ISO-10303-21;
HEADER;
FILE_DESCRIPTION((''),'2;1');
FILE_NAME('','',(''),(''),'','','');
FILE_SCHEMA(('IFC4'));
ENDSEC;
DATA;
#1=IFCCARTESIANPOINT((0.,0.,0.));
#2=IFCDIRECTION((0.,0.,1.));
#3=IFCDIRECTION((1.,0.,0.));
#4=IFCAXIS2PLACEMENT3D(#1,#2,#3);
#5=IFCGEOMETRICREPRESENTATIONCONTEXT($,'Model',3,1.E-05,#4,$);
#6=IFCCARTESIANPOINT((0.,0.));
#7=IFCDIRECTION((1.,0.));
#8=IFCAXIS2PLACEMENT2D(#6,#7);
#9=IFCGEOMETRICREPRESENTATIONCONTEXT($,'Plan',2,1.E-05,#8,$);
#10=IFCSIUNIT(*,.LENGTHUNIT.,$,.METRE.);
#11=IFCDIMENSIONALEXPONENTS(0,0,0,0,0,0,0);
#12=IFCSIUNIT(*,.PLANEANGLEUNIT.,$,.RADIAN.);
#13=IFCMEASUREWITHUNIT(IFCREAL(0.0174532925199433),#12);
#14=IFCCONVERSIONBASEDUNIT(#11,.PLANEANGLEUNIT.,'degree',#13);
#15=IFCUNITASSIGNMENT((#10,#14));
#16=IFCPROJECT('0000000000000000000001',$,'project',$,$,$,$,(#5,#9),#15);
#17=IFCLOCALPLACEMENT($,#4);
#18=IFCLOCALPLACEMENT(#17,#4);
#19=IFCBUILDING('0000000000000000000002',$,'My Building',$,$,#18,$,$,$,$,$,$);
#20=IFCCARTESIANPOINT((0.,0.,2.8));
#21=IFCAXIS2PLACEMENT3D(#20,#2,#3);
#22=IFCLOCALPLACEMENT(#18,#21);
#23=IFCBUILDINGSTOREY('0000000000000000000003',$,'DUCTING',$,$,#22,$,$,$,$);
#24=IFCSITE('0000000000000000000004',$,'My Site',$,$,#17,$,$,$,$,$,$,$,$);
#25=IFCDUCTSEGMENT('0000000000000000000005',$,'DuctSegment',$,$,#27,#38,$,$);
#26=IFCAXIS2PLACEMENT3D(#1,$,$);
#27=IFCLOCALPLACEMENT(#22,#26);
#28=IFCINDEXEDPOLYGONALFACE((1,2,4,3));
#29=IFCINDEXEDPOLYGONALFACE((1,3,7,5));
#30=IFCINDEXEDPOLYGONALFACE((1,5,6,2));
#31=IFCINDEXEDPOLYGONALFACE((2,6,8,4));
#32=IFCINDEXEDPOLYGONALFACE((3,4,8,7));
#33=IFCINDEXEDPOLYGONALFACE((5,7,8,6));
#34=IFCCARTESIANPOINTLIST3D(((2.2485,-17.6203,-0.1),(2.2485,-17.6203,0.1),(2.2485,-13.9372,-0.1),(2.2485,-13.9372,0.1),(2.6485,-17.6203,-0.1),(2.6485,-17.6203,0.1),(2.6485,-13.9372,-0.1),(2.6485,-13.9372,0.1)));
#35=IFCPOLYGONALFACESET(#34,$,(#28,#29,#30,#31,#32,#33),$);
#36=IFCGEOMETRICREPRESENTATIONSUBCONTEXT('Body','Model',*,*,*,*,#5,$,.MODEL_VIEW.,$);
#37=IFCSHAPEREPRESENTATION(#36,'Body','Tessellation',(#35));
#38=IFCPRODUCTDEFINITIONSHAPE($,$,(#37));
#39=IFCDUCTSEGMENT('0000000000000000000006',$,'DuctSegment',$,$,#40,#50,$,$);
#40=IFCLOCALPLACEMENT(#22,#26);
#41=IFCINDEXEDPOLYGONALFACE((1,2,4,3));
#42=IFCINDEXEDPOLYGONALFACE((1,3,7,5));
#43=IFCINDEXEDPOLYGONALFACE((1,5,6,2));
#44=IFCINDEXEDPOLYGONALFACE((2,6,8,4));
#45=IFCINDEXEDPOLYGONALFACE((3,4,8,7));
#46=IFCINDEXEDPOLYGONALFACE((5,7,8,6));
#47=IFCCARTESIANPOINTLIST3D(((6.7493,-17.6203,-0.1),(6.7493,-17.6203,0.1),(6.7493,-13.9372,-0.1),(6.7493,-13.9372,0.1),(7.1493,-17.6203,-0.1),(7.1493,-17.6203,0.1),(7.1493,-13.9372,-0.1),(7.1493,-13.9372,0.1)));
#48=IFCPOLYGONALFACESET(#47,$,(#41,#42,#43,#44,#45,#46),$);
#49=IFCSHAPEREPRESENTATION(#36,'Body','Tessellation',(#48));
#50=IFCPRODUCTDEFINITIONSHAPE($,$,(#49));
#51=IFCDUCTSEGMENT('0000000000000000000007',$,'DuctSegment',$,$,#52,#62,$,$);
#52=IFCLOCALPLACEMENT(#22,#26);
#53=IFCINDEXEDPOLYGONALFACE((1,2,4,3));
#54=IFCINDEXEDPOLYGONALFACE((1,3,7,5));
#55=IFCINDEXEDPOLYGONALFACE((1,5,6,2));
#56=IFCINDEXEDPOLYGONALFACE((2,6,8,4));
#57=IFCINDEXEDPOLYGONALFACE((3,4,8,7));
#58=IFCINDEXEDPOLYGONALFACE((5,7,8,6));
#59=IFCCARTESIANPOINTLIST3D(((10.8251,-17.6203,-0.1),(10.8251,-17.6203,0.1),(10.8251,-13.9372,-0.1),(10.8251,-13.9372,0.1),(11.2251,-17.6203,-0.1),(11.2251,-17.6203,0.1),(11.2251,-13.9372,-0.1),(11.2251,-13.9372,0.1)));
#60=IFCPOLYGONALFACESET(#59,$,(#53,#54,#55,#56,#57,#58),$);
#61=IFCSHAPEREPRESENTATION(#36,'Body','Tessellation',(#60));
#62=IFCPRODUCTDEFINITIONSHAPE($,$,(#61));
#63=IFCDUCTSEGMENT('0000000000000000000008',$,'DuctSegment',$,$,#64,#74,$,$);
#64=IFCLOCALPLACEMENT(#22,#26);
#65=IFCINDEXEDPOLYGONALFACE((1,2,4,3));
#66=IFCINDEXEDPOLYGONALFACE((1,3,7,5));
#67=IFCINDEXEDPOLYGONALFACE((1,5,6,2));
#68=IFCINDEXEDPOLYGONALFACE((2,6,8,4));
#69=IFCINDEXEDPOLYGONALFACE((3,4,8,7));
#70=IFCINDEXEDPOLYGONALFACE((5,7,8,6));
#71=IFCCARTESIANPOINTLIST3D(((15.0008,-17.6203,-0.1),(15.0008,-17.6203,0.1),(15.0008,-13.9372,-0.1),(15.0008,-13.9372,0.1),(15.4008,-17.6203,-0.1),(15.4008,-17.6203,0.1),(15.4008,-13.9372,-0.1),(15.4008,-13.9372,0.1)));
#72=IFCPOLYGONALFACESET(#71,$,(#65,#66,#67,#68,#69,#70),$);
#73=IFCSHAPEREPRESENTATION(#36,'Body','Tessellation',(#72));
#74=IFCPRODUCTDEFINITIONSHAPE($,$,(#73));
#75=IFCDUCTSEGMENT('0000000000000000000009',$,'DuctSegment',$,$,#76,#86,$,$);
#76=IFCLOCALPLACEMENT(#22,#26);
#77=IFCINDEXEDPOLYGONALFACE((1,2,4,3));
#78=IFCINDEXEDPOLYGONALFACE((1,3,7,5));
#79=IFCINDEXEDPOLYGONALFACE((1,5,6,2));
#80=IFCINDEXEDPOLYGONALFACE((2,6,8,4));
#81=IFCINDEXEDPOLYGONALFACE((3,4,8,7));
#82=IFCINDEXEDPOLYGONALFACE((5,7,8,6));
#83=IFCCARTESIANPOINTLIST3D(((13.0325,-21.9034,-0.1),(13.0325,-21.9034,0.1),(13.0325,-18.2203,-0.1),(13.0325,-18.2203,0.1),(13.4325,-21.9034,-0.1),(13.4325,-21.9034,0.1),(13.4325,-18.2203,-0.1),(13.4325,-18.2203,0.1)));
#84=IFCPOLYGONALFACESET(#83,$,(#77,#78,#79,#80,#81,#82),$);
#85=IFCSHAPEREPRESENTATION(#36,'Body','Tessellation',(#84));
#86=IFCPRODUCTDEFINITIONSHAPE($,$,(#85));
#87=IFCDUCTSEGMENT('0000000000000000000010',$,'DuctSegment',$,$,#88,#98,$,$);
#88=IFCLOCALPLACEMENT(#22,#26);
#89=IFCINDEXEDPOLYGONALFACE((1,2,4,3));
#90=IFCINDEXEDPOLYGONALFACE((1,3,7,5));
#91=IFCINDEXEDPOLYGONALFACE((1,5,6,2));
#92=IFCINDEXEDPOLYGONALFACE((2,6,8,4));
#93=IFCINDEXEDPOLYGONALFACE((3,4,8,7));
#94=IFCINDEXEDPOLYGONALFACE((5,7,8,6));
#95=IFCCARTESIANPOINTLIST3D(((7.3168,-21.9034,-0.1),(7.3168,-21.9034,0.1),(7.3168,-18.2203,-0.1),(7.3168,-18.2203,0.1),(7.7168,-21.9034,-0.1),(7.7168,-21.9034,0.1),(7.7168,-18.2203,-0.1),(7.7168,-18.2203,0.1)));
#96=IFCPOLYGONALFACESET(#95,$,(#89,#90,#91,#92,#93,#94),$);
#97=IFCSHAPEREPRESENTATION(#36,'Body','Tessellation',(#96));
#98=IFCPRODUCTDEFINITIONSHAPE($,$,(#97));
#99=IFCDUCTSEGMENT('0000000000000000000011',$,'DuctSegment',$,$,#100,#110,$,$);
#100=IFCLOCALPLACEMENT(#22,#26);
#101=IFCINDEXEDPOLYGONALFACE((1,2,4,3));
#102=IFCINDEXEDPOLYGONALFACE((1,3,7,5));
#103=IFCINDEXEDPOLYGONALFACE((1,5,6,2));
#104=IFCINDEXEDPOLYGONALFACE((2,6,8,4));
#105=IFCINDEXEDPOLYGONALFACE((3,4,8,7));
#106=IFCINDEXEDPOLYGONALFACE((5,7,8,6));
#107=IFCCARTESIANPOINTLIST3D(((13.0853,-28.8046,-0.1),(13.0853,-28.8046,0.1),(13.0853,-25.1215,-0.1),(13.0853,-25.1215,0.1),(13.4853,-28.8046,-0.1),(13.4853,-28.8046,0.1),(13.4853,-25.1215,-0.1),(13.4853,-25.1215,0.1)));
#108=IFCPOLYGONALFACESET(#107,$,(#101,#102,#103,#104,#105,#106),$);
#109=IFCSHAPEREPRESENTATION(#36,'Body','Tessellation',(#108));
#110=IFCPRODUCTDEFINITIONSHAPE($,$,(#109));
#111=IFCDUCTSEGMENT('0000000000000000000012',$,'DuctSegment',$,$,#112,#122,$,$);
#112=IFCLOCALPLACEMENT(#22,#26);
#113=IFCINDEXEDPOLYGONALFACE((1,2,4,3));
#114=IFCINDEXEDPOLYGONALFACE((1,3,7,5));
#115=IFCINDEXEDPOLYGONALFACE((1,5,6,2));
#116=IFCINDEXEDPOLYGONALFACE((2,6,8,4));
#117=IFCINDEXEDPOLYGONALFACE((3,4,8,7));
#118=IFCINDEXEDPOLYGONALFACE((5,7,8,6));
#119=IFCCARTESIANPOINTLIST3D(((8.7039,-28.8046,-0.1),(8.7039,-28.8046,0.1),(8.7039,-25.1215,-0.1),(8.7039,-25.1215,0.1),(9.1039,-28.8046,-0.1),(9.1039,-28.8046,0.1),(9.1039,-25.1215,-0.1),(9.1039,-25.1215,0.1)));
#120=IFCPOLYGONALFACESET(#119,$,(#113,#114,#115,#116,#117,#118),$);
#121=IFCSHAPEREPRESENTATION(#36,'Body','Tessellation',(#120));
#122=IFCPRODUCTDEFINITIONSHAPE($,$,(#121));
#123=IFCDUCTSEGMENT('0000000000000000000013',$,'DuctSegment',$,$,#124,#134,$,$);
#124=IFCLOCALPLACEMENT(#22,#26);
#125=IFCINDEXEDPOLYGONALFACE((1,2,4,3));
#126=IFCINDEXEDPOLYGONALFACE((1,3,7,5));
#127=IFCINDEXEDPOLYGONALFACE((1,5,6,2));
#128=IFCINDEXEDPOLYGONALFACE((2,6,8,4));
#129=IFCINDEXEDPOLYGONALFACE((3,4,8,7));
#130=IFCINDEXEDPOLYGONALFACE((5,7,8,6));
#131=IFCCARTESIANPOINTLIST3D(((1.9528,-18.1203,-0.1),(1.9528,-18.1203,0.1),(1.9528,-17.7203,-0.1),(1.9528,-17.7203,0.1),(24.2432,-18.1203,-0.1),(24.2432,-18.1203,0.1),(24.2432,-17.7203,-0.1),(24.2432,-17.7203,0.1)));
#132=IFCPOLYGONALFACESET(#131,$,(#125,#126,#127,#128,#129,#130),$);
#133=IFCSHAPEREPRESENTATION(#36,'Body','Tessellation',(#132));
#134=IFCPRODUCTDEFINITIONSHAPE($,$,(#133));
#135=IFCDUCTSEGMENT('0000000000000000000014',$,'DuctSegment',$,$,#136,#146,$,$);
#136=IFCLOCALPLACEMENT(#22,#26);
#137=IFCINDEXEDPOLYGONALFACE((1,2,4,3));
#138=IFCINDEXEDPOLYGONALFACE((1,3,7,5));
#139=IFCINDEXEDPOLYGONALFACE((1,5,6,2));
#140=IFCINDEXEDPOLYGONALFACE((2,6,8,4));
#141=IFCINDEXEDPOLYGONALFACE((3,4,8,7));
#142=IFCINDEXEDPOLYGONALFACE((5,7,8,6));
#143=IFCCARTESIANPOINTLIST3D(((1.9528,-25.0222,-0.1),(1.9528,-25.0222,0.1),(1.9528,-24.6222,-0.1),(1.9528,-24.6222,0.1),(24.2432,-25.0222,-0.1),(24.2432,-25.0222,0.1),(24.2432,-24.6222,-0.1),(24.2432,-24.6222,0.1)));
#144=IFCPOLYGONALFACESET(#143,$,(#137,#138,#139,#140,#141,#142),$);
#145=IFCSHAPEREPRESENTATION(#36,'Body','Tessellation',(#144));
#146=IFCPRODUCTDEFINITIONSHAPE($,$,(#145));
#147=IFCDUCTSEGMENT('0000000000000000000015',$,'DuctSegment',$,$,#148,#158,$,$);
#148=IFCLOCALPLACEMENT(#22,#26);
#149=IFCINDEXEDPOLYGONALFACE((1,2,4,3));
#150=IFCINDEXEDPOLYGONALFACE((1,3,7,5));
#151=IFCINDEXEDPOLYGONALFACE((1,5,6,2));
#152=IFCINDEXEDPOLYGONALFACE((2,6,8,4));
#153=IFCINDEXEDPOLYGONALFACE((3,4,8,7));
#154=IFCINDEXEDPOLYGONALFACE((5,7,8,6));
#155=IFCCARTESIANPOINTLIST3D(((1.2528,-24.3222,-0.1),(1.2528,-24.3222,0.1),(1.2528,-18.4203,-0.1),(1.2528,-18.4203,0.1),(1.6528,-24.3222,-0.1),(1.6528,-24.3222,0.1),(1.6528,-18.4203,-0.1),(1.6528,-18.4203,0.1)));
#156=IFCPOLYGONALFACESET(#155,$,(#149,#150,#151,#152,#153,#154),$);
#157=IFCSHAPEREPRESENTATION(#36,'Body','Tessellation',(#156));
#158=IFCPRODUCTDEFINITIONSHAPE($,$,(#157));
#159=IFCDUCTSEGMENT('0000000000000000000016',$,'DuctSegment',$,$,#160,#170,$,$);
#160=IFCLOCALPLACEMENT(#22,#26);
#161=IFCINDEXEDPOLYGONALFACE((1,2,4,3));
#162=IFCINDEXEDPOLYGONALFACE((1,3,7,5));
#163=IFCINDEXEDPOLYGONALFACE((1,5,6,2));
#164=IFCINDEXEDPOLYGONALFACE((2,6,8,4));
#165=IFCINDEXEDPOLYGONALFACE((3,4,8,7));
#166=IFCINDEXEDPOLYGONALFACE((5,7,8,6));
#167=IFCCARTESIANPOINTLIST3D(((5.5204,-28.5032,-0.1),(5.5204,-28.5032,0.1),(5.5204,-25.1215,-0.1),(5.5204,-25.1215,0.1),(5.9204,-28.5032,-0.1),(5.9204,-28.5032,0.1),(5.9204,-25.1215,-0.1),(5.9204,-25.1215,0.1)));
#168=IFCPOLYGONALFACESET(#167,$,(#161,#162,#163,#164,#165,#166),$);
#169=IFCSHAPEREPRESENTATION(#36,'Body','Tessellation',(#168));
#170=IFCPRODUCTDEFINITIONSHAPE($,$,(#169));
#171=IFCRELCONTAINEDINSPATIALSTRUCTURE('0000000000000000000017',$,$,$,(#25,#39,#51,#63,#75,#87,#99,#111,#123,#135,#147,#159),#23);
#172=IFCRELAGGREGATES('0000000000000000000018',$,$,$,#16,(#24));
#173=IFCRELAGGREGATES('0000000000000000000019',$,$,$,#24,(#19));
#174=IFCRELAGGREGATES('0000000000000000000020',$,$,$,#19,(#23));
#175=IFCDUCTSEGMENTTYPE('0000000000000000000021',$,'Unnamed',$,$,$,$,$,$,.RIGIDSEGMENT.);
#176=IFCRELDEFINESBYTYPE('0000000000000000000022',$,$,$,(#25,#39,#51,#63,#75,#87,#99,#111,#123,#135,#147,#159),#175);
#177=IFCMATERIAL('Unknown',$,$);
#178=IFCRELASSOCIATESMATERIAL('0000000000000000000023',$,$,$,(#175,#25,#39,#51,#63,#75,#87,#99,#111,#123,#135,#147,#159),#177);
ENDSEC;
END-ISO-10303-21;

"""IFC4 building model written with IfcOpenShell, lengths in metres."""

from ifc_helpers import new_model, entity, si_unit, converted_unit, frame, origin_with_axes, origin_2d_with_axis, place, context, subcontext, project, spatial, rectangle, extrude, material, material_profile, profile_set, profile_usage, type_object, element, save


model = new_model("IFC4")

# Units and contexts
model_context = context("Model", 3, precision=1e-05, world=origin_with_axes())
plan_context = context("Plan", 2, precision=1e-05, world=origin_2d_with_axis())
body_context = subcontext(model_context, "Body", "Model", "MODEL_VIEW")
ifc_project = project(units=[si_unit("LENGTHUNIT", "METRE"), converted_unit("PLANEANGLEUNIT", "degree", entity("IfcReal", 0.0174532925199433), si_unit("PLANEANGLEUNIT", "RADIAN"), dimensions=[0, 0, 0, 0, 0, 0, 0])], contexts=[model_context, plan_context])

# Site, building, storey
site_placement = place(None, origin_with_axes())
site = spatial("IfcSite", under=ifc_project, at=site_placement, Name="My Site")
building_placement = place(site_placement, origin_with_axes())
building = spatial("IfcBuilding", under=site, at=building_placement, Name="My Building")
storey_placement = place(building_placement, frame((0.0, 0.0, 2.8), z_axis=(0.0, 0.0, 1.0), x_axis=(1.0, 0.0, 0.0)))
storey = spatial("IfcBuildingStorey", under=building, at=storey_placement, Name="DUCTING")

# Duct segments
ifc_material = material(Name="Unknown")
ifc_material_profile_1 = material_profile(ifc_material, rectangle(XDim=0.4, YDim=0.2))
ifc_profile_set_1 = profile_set([ifc_material_profile_1])
ifc_profile_usage_1 = profile_usage(ifc_profile_set_1, cardinal=5)
duct_segment_type = type_object("IfcDuctSegmentType", Name="Unnamed", PredefinedType="RIGIDSEGMENT", material=ifc_profile_set_1)
duct_segment_1_placement = place(storey_placement, frame((2.4485, -13.9372, 0.0), z_axis=(0.0, -1.0, 0.0), x_axis=(1.0, 0.0, 0.0)))
element("IfcDuctSegment", 1, at=duct_segment_1_placement, inside=storey, type_object=duct_segment_type, material=ifc_profile_usage_1, Name="DuctSegment", context=body_context, shape_type="SweptSolid", body=[
    extrude(rectangle(XDim=0.4, YDim=0.2), origin_with_axes(), (0.0, 0.0, 1.0), 3.6831),
])
ifc_profile_usage_2 = profile_usage(ifc_profile_set_1, cardinal=5)
duct_segment_2_placement = place(storey_placement, frame((6.9493, -13.9372, 0.0), z_axis=(0.0, -1.0, 0.0), x_axis=(1.0, 0.0, 0.0)))
element("IfcDuctSegment", 2, at=duct_segment_2_placement, inside=storey, type_object=duct_segment_type, material=ifc_profile_usage_2, Name="DuctSegment", context=body_context, shape_type="SweptSolid", body=[
    extrude(rectangle(XDim=0.4, YDim=0.2), origin_with_axes(), (0.0, 0.0, 1.0), 3.6831),
])
ifc_profile_usage_3 = profile_usage(ifc_profile_set_1, cardinal=5)
duct_segment_3_placement = place(storey_placement, frame((11.0251, -13.9372, 0.0), z_axis=(0.0, -1.0, 0.0), x_axis=(1.0, 0.0, 0.0)))
element("IfcDuctSegment", 3, at=duct_segment_3_placement, inside=storey, type_object=duct_segment_type, material=ifc_profile_usage_3, Name="DuctSegment", context=body_context, shape_type="SweptSolid", body=[
    extrude(rectangle(XDim=0.4, YDim=0.2), origin_with_axes(), (0.0, 0.0, 1.0), 3.6831),
])
ifc_profile_usage_4 = profile_usage(ifc_profile_set_1, cardinal=5)
duct_segment_4_placement = place(storey_placement, frame((15.2008, -13.9372, 0.0), z_axis=(0.0, -1.0, 0.0), x_axis=(1.0, 0.0, 0.0)))
element("IfcDuctSegment", 4, at=duct_segment_4_placement, inside=storey, type_object=duct_segment_type, material=ifc_profile_usage_4, Name="DuctSegment", context=body_context, shape_type="SweptSolid", body=[
    extrude(rectangle(XDim=0.4, YDim=0.2), origin_with_axes(), (0.0, 0.0, 1.0), 3.6831),
])
ifc_profile_usage_5 = profile_usage(ifc_profile_set_1, cardinal=5)
duct_segment_5_placement = place(storey_placement, frame((13.2325, -21.9034, 0.0), z_axis=(0.0, 1.0, 0.0), x_axis=(-1.0, 0.0, 0.0)))
element("IfcDuctSegment", 5, at=duct_segment_5_placement, inside=storey, type_object=duct_segment_type, material=ifc_profile_usage_5, Name="DuctSegment", context=body_context, shape_type="SweptSolid", body=[
    extrude(rectangle(XDim=0.4, YDim=0.2), origin_with_axes(), (0.0, 0.0, 1.0), 3.6831),
])
ifc_profile_usage_6 = profile_usage(ifc_profile_set_1, cardinal=5)
duct_segment_6_placement = place(storey_placement, frame((7.5168, -21.9034, 0.0), z_axis=(0.0, 1.0, 0.0), x_axis=(-1.0, 0.0, 0.0)))
element("IfcDuctSegment", 6, at=duct_segment_6_placement, inside=storey, type_object=duct_segment_type, material=ifc_profile_usage_6, Name="DuctSegment", context=body_context, shape_type="SweptSolid", body=[
    extrude(rectangle(XDim=0.4, YDim=0.2), origin_with_axes(), (0.0, 0.0, 1.0), 3.6831),
])
ifc_profile_usage_7 = profile_usage(ifc_profile_set_1, cardinal=5)
duct_segment_7_placement = place(storey_placement, frame((13.2853, -28.8046, 0.0), z_axis=(0.0, 1.0, 0.0), x_axis=(-1.0, 0.0, 0.0)))
element("IfcDuctSegment", 7, at=duct_segment_7_placement, inside=storey, type_object=duct_segment_type, material=ifc_profile_usage_7, Name="DuctSegment", context=body_context, shape_type="SweptSolid", body=[
    extrude(rectangle(XDim=0.4, YDim=0.2), origin_with_axes(), (0.0, 0.0, 1.0), 3.6831),
])
ifc_profile_usage_8 = profile_usage(ifc_profile_set_1, cardinal=5)
duct_segment_8_placement = place(storey_placement, frame((8.9039, -28.8046, 0.0), z_axis=(0.0, 1.0, 0.0), x_axis=(-1.0, 0.0, 0.0)))
element("IfcDuctSegment", 8, at=duct_segment_8_placement, inside=storey, type_object=duct_segment_type, material=ifc_profile_usage_8, Name="DuctSegment", context=body_context, shape_type="SweptSolid", body=[
    extrude(rectangle(XDim=0.4, YDim=0.2), origin_with_axes(), (0.0, 0.0, 1.0), 3.6831),
])
ifc_profile_usage_9 = profile_usage(ifc_profile_set_1, cardinal=5)
duct_segment_9_placement = place(storey_placement, frame((1.9528, -17.9203, 0.0), z_axis=(1.0, 0.0, 0.0), x_axis=(0.0, 1.0, 0.0)))
element("IfcDuctSegment", 9, at=duct_segment_9_placement, inside=storey, type_object=duct_segment_type, material=ifc_profile_usage_9, Name="DuctSegment", context=body_context, shape_type="SweptSolid", body=[
    extrude(rectangle(XDim=0.4, YDim=0.2), origin_with_axes(), (0.0, 0.0, 1.0), 22.2903),
])
ifc_profile_usage_10 = profile_usage(ifc_profile_set_1, cardinal=5)
duct_segment_10_placement = place(storey_placement, frame((1.9528, -24.8222, 0.0), z_axis=(1.0, 0.0, 0.0), x_axis=(0.0, 1.0, 0.0)))
element("IfcDuctSegment", 10, at=duct_segment_10_placement, inside=storey, type_object=duct_segment_type, material=ifc_profile_usage_10, Name="DuctSegment", context=body_context, shape_type="SweptSolid", body=[
    extrude(rectangle(XDim=0.4, YDim=0.2), origin_with_axes(), (0.0, 0.0, 1.0), 22.2903),
])
ifc_profile_usage_11 = profile_usage(ifc_profile_set_1, cardinal=5)
duct_segment_11_placement = place(storey_placement, frame((1.4528, -24.3222, 0.0), z_axis=(0.0, 1.0, 0.0), x_axis=(-1.0, 0.0, 0.0)))
element("IfcDuctSegment", 11, at=duct_segment_11_placement, inside=storey, type_object=duct_segment_type, material=ifc_profile_usage_11, Name="DuctSegment", context=body_context, shape_type="SweptSolid", body=[
    extrude(rectangle(XDim=0.4, YDim=0.2), origin_with_axes(), (0.0, 0.0, 1.0), 5.9019),
])
ifc_profile_usage_12 = profile_usage(ifc_profile_set_1, cardinal=5)
duct_segment_12_placement = place(storey_placement, frame((5.7204, -28.5032, 0.0), z_axis=(0.0, 1.0, 0.0), x_axis=(-1.0, 0.0, 0.0)))
element("IfcDuctSegment", 12, at=duct_segment_12_placement, inside=storey, type_object=duct_segment_type, material=ifc_profile_usage_12, Name="DuctSegment", context=body_context, shape_type="SweptSolid", body=[
    extrude(rectangle(XDim=0.4, YDim=0.2), origin_with_axes(), (0.0, 0.0, 1.0), 3.3816),
])

save(model, "model.ifc")
